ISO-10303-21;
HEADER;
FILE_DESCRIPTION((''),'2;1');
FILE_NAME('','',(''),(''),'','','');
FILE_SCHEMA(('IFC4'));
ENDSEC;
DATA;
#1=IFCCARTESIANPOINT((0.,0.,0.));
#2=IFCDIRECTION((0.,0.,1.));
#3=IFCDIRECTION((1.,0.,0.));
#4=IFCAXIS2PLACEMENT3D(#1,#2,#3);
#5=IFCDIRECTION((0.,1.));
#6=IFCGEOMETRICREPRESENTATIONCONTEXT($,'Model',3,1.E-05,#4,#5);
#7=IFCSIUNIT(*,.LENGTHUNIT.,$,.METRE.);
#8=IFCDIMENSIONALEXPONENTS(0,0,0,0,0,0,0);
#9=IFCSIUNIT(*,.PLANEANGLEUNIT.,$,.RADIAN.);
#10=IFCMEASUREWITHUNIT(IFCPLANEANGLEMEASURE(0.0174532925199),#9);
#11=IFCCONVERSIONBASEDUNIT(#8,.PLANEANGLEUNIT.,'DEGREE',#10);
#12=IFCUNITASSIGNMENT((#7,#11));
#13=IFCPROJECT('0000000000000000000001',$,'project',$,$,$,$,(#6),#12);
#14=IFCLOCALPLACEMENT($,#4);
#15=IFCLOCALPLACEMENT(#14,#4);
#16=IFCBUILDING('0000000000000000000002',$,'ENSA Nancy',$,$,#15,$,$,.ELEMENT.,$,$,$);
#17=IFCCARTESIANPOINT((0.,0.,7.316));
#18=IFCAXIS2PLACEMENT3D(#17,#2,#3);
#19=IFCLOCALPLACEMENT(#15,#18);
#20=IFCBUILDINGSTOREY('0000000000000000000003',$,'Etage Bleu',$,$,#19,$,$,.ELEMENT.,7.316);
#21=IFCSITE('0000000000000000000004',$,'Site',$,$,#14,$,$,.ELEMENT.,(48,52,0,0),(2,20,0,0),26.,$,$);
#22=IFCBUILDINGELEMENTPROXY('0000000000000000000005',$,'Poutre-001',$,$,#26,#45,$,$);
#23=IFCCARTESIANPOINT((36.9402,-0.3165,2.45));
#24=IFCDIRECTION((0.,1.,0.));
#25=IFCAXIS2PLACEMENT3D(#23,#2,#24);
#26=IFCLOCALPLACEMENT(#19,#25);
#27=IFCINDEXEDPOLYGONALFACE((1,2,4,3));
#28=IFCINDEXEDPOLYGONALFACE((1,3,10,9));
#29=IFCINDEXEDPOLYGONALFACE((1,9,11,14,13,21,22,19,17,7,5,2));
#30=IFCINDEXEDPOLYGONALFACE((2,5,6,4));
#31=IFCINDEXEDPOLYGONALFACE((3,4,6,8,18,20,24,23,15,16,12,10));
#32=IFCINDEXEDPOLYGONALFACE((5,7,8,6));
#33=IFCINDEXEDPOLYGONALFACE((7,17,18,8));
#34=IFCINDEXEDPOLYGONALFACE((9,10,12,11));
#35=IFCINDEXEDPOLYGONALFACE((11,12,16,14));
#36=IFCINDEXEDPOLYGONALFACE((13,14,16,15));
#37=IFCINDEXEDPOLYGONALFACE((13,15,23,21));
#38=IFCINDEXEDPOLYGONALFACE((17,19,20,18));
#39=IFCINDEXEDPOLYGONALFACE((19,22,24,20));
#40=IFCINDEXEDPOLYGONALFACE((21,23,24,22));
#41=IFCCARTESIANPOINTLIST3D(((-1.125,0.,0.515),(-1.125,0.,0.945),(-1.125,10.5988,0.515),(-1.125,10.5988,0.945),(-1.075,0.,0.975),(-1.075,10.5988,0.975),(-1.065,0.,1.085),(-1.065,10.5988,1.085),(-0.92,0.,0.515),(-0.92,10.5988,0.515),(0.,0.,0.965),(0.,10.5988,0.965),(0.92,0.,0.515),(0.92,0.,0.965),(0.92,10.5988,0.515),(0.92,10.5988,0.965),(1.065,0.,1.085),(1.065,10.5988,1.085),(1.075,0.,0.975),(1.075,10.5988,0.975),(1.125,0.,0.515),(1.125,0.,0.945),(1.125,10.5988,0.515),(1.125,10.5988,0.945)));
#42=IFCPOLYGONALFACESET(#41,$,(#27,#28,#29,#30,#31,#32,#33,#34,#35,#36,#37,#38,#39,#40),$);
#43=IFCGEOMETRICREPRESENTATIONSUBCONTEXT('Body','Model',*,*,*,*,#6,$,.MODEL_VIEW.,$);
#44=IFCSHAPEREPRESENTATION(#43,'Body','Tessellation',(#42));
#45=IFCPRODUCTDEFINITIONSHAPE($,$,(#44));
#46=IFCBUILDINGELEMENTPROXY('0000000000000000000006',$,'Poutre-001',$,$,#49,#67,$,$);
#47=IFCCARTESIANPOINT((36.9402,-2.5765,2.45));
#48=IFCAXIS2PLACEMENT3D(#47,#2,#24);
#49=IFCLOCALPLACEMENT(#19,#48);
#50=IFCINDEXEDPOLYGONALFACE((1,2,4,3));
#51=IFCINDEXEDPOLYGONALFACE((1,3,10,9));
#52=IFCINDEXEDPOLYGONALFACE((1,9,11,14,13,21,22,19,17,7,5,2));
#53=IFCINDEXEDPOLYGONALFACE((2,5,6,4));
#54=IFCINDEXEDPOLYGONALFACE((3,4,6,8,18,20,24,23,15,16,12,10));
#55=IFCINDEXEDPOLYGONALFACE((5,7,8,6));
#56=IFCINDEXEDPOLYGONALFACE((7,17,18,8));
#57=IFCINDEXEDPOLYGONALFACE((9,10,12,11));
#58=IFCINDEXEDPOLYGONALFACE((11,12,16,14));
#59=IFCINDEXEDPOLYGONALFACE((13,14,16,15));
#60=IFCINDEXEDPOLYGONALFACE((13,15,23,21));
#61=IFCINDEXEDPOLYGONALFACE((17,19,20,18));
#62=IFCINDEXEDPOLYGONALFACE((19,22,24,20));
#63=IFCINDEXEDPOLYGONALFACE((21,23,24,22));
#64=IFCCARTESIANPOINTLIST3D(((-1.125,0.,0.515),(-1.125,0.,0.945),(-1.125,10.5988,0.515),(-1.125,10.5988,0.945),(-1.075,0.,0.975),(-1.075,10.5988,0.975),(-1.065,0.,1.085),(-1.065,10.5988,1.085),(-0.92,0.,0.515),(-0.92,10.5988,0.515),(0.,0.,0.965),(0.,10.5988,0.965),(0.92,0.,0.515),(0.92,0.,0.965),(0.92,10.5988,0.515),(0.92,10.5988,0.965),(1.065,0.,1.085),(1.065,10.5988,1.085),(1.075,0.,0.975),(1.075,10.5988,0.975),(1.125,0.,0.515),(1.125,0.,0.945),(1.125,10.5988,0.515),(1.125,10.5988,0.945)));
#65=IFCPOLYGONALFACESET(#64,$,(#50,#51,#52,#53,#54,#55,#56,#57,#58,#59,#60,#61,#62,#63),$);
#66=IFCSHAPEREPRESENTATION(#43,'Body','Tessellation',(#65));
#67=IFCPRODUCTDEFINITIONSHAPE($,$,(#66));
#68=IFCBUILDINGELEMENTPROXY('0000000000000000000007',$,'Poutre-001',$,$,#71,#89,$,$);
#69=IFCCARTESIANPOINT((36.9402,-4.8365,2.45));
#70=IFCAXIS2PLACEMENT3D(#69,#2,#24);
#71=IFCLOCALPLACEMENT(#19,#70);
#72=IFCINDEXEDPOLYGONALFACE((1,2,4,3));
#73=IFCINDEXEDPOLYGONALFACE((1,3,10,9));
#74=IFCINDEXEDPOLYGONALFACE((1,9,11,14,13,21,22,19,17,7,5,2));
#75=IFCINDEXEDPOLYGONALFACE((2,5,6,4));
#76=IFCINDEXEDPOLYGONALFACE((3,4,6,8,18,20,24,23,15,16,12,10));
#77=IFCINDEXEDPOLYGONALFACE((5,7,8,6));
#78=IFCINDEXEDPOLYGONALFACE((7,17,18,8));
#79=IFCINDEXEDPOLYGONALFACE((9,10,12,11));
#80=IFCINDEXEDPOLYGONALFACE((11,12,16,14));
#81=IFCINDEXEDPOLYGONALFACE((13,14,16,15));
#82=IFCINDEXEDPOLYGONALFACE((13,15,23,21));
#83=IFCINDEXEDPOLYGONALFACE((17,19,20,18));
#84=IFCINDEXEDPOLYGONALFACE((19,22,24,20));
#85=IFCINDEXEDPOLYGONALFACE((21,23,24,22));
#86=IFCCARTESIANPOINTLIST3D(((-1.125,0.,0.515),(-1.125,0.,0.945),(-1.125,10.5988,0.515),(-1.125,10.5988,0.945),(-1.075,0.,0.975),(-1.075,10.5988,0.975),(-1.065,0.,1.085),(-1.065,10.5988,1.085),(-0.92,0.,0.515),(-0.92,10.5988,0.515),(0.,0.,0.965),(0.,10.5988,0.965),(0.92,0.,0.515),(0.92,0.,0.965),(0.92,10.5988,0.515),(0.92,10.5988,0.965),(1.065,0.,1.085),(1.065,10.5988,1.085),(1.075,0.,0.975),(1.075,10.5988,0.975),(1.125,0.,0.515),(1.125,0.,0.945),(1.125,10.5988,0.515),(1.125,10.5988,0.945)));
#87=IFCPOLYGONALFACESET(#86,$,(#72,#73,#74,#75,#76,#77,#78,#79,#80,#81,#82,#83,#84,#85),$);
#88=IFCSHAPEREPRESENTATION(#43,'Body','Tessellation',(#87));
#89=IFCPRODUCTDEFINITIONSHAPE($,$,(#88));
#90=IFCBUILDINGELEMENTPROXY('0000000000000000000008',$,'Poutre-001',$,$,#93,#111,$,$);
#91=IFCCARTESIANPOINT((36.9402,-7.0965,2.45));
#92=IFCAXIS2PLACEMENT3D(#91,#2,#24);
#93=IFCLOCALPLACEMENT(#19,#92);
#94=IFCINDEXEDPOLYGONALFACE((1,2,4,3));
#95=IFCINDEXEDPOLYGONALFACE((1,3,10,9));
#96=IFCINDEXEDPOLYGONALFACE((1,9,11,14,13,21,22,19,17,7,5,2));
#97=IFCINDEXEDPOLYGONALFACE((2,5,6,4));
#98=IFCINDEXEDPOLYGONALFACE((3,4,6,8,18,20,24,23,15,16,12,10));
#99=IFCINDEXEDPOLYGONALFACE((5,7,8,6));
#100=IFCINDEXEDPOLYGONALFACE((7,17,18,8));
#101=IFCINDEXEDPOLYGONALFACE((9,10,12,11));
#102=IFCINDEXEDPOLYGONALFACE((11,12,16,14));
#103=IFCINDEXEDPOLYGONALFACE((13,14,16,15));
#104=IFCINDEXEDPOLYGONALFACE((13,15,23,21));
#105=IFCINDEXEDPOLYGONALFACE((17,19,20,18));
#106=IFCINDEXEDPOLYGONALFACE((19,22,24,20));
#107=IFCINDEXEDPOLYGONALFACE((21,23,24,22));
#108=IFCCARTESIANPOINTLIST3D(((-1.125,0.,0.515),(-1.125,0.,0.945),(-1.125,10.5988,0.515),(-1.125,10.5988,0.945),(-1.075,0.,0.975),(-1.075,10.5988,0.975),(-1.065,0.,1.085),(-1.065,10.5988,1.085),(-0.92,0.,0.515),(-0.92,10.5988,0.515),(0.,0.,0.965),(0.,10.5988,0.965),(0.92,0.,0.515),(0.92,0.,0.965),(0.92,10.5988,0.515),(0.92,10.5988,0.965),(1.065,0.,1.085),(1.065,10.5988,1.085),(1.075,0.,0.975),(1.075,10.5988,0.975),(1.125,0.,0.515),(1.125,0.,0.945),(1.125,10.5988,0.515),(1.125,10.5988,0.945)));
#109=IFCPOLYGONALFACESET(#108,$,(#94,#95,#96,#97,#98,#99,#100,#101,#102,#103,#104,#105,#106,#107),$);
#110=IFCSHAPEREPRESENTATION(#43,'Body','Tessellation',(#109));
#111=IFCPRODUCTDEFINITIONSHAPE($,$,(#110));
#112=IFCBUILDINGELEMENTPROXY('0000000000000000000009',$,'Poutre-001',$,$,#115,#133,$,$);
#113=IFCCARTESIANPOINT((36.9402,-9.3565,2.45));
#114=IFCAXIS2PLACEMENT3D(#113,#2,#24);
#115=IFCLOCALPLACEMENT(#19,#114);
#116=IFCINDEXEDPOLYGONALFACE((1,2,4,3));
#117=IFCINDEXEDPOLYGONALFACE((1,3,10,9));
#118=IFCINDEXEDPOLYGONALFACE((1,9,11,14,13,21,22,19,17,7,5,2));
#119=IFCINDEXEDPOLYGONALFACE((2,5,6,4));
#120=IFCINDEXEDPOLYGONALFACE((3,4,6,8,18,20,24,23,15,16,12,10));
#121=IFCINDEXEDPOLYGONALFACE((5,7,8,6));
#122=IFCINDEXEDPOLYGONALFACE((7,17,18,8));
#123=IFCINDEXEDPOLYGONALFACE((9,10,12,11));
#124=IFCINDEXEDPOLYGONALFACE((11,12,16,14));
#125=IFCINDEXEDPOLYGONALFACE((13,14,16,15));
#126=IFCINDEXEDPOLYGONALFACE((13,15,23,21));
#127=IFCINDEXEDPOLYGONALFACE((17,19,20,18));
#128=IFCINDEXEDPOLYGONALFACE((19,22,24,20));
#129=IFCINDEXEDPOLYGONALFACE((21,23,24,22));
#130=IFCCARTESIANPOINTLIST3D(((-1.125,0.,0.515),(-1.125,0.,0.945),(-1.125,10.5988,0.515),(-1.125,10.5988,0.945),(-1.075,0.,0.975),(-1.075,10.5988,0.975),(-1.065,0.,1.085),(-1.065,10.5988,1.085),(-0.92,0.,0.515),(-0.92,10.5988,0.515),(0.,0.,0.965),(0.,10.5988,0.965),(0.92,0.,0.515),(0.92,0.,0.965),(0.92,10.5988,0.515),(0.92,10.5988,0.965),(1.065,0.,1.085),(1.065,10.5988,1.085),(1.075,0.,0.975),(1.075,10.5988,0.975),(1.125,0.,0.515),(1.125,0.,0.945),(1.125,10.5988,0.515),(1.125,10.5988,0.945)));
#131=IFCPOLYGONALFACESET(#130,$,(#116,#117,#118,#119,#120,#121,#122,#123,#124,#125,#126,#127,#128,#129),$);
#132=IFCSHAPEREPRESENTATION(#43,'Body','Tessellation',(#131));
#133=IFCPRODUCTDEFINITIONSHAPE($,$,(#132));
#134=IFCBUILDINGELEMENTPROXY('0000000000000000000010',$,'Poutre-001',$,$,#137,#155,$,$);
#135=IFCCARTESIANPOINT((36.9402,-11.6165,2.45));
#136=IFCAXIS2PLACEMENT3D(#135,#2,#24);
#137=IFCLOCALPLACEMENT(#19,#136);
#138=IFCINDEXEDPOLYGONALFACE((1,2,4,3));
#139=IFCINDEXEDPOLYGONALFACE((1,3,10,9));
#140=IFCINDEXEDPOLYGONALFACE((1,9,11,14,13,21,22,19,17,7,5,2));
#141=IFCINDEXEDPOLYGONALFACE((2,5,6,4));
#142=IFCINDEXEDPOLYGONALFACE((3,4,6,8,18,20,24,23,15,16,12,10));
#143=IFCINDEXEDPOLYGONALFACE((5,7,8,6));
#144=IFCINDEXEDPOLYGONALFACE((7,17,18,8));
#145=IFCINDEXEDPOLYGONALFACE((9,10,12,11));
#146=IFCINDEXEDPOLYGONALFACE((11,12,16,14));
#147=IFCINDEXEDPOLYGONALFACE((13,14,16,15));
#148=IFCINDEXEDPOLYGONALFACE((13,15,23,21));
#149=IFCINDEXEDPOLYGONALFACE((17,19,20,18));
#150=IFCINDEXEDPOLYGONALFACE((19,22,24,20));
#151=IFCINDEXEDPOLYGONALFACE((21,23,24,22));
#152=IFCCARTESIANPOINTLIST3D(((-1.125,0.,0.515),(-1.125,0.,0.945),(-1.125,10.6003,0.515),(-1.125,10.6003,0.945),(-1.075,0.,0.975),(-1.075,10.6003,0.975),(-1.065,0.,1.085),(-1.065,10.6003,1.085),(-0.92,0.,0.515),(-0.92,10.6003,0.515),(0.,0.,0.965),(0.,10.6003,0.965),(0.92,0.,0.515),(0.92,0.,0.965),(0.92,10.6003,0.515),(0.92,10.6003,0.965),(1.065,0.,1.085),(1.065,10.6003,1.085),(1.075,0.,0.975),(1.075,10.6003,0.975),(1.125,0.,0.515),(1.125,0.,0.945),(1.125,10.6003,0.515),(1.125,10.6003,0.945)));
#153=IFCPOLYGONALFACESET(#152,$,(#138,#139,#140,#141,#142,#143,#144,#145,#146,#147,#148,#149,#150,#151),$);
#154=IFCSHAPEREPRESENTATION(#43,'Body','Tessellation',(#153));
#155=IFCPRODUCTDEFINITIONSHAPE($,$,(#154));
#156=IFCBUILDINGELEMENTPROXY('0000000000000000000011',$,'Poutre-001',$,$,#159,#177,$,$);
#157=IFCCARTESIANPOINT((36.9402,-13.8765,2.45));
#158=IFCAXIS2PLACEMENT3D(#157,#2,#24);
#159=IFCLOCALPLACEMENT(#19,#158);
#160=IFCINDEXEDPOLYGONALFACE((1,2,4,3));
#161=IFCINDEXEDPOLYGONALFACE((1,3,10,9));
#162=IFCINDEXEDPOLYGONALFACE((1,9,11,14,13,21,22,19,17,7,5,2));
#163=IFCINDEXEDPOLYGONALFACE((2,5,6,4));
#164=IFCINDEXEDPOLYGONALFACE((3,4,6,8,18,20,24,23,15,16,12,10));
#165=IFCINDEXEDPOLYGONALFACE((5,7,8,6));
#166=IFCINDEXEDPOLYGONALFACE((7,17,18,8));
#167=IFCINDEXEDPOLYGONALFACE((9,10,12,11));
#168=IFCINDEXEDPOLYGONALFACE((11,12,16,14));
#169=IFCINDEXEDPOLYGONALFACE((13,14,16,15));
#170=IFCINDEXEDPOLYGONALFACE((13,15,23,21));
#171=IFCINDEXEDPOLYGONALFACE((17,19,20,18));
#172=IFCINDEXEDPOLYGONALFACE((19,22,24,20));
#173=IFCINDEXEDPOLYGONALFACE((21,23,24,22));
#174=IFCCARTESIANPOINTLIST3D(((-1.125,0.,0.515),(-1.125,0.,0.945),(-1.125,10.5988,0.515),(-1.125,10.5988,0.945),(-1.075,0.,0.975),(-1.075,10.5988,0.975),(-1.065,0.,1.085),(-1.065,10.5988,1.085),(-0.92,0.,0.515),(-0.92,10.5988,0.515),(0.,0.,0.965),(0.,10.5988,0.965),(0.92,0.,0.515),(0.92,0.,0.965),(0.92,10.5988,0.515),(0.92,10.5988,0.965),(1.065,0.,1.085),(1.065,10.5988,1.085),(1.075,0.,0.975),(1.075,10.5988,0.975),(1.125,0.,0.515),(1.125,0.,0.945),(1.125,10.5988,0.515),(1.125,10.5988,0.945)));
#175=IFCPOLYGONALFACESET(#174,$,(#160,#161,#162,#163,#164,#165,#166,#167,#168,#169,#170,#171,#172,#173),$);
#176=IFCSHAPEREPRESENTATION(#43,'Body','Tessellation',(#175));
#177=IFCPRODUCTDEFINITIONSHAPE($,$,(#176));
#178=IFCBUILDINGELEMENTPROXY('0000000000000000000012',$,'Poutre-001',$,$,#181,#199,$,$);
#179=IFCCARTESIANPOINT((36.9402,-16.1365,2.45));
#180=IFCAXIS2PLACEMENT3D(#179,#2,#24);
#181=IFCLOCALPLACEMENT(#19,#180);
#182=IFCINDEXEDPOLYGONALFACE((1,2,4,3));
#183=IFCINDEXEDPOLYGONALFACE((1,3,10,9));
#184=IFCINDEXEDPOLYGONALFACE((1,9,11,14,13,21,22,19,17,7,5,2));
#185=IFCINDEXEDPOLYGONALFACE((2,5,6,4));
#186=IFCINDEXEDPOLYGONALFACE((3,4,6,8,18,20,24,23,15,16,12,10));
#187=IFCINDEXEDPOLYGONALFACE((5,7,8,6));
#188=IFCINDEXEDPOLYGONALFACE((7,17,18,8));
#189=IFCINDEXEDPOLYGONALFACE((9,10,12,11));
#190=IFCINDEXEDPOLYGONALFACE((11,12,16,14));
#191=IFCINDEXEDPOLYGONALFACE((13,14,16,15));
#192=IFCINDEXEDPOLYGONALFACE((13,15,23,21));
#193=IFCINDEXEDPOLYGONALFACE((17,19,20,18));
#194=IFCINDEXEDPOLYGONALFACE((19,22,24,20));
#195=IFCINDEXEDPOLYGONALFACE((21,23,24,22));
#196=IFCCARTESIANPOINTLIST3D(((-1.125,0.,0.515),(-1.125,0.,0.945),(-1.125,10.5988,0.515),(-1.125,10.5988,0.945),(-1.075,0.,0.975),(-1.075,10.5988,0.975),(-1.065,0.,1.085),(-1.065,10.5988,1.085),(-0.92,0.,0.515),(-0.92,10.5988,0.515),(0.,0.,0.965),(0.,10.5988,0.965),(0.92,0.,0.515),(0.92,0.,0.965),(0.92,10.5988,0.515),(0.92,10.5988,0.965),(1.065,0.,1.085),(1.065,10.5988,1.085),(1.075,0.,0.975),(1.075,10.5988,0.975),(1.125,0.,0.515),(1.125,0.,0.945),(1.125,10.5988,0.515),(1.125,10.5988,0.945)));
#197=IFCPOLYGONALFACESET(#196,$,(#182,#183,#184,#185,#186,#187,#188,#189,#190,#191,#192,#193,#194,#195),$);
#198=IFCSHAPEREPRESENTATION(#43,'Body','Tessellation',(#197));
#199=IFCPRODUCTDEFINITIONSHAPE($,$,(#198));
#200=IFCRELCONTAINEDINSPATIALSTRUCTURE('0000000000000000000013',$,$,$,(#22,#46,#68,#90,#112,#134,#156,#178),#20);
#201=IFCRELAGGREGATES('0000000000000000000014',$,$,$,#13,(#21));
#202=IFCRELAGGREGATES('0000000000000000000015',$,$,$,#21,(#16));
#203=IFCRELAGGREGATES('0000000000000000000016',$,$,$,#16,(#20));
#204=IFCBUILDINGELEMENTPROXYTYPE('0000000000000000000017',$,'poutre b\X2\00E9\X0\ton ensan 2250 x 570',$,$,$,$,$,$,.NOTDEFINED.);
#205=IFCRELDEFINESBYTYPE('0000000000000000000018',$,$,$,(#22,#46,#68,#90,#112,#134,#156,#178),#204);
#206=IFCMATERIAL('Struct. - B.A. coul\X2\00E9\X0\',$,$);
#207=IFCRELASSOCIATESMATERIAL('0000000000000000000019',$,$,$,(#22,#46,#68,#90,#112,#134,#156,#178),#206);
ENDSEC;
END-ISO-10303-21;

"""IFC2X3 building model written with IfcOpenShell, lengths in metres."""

from ifc_helpers import new_model, entity, si_unit, converted_unit, direction, frame, origin_with_axes, place, context, subcontext, project, spatial, polyline, outline, extrude, material, type_object, element, save


model = new_model("IFC2X3")

# Units and contexts
model_context = context("Model", 3, precision=1e-05, world=origin_with_axes(), true_north=direction((0.0, 1.0)))
body_context = subcontext(model_context, "Body", "Model", "MODEL_VIEW")
ifc_project = project(units=[si_unit("LENGTHUNIT", "METRE"), converted_unit("PLANEANGLEUNIT", "DEGREE", entity("IfcPlaneAngleMeasure", 0.0174532925199), si_unit("PLANEANGLEUNIT", "RADIAN"), dimensions=[0, 0, 0, 0, 0, 0, 0])], contexts=[model_context])

# Site, building, storey
site_placement = place(None, origin_with_axes())
site = spatial("IfcSite", under=ifc_project, at=site_placement, Name="Site", CompositionType="ELEMENT", RefLatitude=(48, 52, 0, 0), RefLongitude=(2, 20, 0, 0), RefElevation=26.0)
building_placement = place(site_placement, origin_with_axes())
building = spatial("IfcBuilding", under=site, at=building_placement, Name="ENSA Nancy", CompositionType="ELEMENT")
storey_placement = place(building_placement, frame((0.0, 0.0, 7.316), z_axis=(0.0, 0.0, 1.0), x_axis=(1.0, 0.0, 0.0)))
storey = spatial("IfcBuildingStorey", under=building, at=storey_placement, Name="Etage Bleu", CompositionType="ELEMENT", Elevation=7.316)

# Building element proxies
ifc_material = material(Name="Struct. - B.A. coulé")
building_element_proxy_type = type_object("IfcBuildingElementProxyType", Name="poutre béton ensan 2250 x 570", PredefinedType="NOTDEFINED")
for number, where, z_axis, x_axis, name in (
    (1, (36.9402, -0.3165, 2.45), (0.0, 0.0, 1.0), (0.0, 1.0, 0.0), "Poutre-001"),
    (2, (36.9402, -2.5765, 2.45), (0.0, 0.0, 1.0), (0.0, 1.0, 0.0), "Poutre-001"),
    (3, (36.9402, -4.8365, 2.45), (0.0, 0.0, 1.0), (0.0, 1.0, 0.0), "Poutre-001"),
    (4, (36.9402, -7.0965, 2.45), (0.0, 0.0, 1.0), (0.0, 1.0, 0.0), "Poutre-001"),
    (5, (36.9402, -9.3565, 2.45), (0.0, 0.0, 1.0), (0.0, 1.0, 0.0), "Poutre-001"),
):
    element("IfcBuildingElementProxy", number, at=place(storey_placement, frame(where, z_axis=z_axis, x_axis=x_axis)), inside=storey, type_object=building_element_proxy_type, material=ifc_material, Name=name, context=body_context, shape_type="SweptSolid", body=[
        extrude(outline(polyline([(-1.065, 1.085), (-1.075, 0.975), (-1.125, 0.945), (-1.125, 0.515), (-0.92, 0.515), (0.0, 0.965), (0.92, 0.965), (0.92, 0.515), (1.125, 0.515), (1.125, 0.945), (1.075, 0.975), (1.065, 1.085), (-1.065, 1.085)])), frame((0.0, 10.5988, 0.0), z_axis=(0.0, -1.0, 0.0), x_axis=(1.0, 0.0, 0.0)), (0.0, 0.0, 1.0), 10.5988),
    ])
proxy_1_placement = place(storey_placement, frame((36.9402, -11.6165, 2.45), z_axis=(0.0, 0.0, 1.0), x_axis=(0.0, 1.0, 0.0)))
element("IfcBuildingElementProxy", 6, at=proxy_1_placement, inside=storey, type_object=building_element_proxy_type, material=ifc_material, Name="Poutre-001", context=body_context, shape_type="SweptSolid", body=[
    extrude(outline(polyline([(-1.065, 1.085), (-1.075, 0.975), (-1.125, 0.945), (-1.125, 0.515), (-0.92, 0.515), (0.0, 0.965), (0.92, 0.965), (0.92, 0.515), (1.125, 0.515), (1.125, 0.945), (1.075, 0.975), (1.065, 1.085), (-1.065, 1.085)])), frame((0.0, 10.6003, 0.0), z_axis=(0.0, -1.0, 0.0), x_axis=(1.0, 0.0, 0.0)), (0.0, 0.0, 1.0), 10.6003),
])
for number, where, z_axis, x_axis, name in (
    (7, (36.9402, -13.8765, 2.45), (0.0, 0.0, 1.0), (0.0, 1.0, 0.0), "Poutre-001"),
    (8, (36.9402, -16.1365, 2.45), (0.0, 0.0, 1.0), (0.0, 1.0, 0.0), "Poutre-001"),
):
    element("IfcBuildingElementProxy", number, at=place(storey_placement, frame(where, z_axis=z_axis, x_axis=x_axis)), inside=storey, type_object=building_element_proxy_type, material=ifc_material, Name=name, context=body_context, shape_type="SweptSolid", body=[
        extrude(outline(polyline([(-1.065, 1.085), (-1.075, 0.975), (-1.125, 0.945), (-1.125, 0.515), (-0.92, 0.515), (0.0, 0.965), (0.92, 0.965), (0.92, 0.515), (1.125, 0.515), (1.125, 0.945), (1.075, 0.975), (1.065, 1.085), (-1.065, 1.085)])), frame((0.0, 10.5988, 0.0), z_axis=(0.0, -1.0, 0.0), x_axis=(1.0, 0.0, 0.0)), (0.0, 0.0, 1.0), 10.5988),
    ])

save(model, "model.ifc")
